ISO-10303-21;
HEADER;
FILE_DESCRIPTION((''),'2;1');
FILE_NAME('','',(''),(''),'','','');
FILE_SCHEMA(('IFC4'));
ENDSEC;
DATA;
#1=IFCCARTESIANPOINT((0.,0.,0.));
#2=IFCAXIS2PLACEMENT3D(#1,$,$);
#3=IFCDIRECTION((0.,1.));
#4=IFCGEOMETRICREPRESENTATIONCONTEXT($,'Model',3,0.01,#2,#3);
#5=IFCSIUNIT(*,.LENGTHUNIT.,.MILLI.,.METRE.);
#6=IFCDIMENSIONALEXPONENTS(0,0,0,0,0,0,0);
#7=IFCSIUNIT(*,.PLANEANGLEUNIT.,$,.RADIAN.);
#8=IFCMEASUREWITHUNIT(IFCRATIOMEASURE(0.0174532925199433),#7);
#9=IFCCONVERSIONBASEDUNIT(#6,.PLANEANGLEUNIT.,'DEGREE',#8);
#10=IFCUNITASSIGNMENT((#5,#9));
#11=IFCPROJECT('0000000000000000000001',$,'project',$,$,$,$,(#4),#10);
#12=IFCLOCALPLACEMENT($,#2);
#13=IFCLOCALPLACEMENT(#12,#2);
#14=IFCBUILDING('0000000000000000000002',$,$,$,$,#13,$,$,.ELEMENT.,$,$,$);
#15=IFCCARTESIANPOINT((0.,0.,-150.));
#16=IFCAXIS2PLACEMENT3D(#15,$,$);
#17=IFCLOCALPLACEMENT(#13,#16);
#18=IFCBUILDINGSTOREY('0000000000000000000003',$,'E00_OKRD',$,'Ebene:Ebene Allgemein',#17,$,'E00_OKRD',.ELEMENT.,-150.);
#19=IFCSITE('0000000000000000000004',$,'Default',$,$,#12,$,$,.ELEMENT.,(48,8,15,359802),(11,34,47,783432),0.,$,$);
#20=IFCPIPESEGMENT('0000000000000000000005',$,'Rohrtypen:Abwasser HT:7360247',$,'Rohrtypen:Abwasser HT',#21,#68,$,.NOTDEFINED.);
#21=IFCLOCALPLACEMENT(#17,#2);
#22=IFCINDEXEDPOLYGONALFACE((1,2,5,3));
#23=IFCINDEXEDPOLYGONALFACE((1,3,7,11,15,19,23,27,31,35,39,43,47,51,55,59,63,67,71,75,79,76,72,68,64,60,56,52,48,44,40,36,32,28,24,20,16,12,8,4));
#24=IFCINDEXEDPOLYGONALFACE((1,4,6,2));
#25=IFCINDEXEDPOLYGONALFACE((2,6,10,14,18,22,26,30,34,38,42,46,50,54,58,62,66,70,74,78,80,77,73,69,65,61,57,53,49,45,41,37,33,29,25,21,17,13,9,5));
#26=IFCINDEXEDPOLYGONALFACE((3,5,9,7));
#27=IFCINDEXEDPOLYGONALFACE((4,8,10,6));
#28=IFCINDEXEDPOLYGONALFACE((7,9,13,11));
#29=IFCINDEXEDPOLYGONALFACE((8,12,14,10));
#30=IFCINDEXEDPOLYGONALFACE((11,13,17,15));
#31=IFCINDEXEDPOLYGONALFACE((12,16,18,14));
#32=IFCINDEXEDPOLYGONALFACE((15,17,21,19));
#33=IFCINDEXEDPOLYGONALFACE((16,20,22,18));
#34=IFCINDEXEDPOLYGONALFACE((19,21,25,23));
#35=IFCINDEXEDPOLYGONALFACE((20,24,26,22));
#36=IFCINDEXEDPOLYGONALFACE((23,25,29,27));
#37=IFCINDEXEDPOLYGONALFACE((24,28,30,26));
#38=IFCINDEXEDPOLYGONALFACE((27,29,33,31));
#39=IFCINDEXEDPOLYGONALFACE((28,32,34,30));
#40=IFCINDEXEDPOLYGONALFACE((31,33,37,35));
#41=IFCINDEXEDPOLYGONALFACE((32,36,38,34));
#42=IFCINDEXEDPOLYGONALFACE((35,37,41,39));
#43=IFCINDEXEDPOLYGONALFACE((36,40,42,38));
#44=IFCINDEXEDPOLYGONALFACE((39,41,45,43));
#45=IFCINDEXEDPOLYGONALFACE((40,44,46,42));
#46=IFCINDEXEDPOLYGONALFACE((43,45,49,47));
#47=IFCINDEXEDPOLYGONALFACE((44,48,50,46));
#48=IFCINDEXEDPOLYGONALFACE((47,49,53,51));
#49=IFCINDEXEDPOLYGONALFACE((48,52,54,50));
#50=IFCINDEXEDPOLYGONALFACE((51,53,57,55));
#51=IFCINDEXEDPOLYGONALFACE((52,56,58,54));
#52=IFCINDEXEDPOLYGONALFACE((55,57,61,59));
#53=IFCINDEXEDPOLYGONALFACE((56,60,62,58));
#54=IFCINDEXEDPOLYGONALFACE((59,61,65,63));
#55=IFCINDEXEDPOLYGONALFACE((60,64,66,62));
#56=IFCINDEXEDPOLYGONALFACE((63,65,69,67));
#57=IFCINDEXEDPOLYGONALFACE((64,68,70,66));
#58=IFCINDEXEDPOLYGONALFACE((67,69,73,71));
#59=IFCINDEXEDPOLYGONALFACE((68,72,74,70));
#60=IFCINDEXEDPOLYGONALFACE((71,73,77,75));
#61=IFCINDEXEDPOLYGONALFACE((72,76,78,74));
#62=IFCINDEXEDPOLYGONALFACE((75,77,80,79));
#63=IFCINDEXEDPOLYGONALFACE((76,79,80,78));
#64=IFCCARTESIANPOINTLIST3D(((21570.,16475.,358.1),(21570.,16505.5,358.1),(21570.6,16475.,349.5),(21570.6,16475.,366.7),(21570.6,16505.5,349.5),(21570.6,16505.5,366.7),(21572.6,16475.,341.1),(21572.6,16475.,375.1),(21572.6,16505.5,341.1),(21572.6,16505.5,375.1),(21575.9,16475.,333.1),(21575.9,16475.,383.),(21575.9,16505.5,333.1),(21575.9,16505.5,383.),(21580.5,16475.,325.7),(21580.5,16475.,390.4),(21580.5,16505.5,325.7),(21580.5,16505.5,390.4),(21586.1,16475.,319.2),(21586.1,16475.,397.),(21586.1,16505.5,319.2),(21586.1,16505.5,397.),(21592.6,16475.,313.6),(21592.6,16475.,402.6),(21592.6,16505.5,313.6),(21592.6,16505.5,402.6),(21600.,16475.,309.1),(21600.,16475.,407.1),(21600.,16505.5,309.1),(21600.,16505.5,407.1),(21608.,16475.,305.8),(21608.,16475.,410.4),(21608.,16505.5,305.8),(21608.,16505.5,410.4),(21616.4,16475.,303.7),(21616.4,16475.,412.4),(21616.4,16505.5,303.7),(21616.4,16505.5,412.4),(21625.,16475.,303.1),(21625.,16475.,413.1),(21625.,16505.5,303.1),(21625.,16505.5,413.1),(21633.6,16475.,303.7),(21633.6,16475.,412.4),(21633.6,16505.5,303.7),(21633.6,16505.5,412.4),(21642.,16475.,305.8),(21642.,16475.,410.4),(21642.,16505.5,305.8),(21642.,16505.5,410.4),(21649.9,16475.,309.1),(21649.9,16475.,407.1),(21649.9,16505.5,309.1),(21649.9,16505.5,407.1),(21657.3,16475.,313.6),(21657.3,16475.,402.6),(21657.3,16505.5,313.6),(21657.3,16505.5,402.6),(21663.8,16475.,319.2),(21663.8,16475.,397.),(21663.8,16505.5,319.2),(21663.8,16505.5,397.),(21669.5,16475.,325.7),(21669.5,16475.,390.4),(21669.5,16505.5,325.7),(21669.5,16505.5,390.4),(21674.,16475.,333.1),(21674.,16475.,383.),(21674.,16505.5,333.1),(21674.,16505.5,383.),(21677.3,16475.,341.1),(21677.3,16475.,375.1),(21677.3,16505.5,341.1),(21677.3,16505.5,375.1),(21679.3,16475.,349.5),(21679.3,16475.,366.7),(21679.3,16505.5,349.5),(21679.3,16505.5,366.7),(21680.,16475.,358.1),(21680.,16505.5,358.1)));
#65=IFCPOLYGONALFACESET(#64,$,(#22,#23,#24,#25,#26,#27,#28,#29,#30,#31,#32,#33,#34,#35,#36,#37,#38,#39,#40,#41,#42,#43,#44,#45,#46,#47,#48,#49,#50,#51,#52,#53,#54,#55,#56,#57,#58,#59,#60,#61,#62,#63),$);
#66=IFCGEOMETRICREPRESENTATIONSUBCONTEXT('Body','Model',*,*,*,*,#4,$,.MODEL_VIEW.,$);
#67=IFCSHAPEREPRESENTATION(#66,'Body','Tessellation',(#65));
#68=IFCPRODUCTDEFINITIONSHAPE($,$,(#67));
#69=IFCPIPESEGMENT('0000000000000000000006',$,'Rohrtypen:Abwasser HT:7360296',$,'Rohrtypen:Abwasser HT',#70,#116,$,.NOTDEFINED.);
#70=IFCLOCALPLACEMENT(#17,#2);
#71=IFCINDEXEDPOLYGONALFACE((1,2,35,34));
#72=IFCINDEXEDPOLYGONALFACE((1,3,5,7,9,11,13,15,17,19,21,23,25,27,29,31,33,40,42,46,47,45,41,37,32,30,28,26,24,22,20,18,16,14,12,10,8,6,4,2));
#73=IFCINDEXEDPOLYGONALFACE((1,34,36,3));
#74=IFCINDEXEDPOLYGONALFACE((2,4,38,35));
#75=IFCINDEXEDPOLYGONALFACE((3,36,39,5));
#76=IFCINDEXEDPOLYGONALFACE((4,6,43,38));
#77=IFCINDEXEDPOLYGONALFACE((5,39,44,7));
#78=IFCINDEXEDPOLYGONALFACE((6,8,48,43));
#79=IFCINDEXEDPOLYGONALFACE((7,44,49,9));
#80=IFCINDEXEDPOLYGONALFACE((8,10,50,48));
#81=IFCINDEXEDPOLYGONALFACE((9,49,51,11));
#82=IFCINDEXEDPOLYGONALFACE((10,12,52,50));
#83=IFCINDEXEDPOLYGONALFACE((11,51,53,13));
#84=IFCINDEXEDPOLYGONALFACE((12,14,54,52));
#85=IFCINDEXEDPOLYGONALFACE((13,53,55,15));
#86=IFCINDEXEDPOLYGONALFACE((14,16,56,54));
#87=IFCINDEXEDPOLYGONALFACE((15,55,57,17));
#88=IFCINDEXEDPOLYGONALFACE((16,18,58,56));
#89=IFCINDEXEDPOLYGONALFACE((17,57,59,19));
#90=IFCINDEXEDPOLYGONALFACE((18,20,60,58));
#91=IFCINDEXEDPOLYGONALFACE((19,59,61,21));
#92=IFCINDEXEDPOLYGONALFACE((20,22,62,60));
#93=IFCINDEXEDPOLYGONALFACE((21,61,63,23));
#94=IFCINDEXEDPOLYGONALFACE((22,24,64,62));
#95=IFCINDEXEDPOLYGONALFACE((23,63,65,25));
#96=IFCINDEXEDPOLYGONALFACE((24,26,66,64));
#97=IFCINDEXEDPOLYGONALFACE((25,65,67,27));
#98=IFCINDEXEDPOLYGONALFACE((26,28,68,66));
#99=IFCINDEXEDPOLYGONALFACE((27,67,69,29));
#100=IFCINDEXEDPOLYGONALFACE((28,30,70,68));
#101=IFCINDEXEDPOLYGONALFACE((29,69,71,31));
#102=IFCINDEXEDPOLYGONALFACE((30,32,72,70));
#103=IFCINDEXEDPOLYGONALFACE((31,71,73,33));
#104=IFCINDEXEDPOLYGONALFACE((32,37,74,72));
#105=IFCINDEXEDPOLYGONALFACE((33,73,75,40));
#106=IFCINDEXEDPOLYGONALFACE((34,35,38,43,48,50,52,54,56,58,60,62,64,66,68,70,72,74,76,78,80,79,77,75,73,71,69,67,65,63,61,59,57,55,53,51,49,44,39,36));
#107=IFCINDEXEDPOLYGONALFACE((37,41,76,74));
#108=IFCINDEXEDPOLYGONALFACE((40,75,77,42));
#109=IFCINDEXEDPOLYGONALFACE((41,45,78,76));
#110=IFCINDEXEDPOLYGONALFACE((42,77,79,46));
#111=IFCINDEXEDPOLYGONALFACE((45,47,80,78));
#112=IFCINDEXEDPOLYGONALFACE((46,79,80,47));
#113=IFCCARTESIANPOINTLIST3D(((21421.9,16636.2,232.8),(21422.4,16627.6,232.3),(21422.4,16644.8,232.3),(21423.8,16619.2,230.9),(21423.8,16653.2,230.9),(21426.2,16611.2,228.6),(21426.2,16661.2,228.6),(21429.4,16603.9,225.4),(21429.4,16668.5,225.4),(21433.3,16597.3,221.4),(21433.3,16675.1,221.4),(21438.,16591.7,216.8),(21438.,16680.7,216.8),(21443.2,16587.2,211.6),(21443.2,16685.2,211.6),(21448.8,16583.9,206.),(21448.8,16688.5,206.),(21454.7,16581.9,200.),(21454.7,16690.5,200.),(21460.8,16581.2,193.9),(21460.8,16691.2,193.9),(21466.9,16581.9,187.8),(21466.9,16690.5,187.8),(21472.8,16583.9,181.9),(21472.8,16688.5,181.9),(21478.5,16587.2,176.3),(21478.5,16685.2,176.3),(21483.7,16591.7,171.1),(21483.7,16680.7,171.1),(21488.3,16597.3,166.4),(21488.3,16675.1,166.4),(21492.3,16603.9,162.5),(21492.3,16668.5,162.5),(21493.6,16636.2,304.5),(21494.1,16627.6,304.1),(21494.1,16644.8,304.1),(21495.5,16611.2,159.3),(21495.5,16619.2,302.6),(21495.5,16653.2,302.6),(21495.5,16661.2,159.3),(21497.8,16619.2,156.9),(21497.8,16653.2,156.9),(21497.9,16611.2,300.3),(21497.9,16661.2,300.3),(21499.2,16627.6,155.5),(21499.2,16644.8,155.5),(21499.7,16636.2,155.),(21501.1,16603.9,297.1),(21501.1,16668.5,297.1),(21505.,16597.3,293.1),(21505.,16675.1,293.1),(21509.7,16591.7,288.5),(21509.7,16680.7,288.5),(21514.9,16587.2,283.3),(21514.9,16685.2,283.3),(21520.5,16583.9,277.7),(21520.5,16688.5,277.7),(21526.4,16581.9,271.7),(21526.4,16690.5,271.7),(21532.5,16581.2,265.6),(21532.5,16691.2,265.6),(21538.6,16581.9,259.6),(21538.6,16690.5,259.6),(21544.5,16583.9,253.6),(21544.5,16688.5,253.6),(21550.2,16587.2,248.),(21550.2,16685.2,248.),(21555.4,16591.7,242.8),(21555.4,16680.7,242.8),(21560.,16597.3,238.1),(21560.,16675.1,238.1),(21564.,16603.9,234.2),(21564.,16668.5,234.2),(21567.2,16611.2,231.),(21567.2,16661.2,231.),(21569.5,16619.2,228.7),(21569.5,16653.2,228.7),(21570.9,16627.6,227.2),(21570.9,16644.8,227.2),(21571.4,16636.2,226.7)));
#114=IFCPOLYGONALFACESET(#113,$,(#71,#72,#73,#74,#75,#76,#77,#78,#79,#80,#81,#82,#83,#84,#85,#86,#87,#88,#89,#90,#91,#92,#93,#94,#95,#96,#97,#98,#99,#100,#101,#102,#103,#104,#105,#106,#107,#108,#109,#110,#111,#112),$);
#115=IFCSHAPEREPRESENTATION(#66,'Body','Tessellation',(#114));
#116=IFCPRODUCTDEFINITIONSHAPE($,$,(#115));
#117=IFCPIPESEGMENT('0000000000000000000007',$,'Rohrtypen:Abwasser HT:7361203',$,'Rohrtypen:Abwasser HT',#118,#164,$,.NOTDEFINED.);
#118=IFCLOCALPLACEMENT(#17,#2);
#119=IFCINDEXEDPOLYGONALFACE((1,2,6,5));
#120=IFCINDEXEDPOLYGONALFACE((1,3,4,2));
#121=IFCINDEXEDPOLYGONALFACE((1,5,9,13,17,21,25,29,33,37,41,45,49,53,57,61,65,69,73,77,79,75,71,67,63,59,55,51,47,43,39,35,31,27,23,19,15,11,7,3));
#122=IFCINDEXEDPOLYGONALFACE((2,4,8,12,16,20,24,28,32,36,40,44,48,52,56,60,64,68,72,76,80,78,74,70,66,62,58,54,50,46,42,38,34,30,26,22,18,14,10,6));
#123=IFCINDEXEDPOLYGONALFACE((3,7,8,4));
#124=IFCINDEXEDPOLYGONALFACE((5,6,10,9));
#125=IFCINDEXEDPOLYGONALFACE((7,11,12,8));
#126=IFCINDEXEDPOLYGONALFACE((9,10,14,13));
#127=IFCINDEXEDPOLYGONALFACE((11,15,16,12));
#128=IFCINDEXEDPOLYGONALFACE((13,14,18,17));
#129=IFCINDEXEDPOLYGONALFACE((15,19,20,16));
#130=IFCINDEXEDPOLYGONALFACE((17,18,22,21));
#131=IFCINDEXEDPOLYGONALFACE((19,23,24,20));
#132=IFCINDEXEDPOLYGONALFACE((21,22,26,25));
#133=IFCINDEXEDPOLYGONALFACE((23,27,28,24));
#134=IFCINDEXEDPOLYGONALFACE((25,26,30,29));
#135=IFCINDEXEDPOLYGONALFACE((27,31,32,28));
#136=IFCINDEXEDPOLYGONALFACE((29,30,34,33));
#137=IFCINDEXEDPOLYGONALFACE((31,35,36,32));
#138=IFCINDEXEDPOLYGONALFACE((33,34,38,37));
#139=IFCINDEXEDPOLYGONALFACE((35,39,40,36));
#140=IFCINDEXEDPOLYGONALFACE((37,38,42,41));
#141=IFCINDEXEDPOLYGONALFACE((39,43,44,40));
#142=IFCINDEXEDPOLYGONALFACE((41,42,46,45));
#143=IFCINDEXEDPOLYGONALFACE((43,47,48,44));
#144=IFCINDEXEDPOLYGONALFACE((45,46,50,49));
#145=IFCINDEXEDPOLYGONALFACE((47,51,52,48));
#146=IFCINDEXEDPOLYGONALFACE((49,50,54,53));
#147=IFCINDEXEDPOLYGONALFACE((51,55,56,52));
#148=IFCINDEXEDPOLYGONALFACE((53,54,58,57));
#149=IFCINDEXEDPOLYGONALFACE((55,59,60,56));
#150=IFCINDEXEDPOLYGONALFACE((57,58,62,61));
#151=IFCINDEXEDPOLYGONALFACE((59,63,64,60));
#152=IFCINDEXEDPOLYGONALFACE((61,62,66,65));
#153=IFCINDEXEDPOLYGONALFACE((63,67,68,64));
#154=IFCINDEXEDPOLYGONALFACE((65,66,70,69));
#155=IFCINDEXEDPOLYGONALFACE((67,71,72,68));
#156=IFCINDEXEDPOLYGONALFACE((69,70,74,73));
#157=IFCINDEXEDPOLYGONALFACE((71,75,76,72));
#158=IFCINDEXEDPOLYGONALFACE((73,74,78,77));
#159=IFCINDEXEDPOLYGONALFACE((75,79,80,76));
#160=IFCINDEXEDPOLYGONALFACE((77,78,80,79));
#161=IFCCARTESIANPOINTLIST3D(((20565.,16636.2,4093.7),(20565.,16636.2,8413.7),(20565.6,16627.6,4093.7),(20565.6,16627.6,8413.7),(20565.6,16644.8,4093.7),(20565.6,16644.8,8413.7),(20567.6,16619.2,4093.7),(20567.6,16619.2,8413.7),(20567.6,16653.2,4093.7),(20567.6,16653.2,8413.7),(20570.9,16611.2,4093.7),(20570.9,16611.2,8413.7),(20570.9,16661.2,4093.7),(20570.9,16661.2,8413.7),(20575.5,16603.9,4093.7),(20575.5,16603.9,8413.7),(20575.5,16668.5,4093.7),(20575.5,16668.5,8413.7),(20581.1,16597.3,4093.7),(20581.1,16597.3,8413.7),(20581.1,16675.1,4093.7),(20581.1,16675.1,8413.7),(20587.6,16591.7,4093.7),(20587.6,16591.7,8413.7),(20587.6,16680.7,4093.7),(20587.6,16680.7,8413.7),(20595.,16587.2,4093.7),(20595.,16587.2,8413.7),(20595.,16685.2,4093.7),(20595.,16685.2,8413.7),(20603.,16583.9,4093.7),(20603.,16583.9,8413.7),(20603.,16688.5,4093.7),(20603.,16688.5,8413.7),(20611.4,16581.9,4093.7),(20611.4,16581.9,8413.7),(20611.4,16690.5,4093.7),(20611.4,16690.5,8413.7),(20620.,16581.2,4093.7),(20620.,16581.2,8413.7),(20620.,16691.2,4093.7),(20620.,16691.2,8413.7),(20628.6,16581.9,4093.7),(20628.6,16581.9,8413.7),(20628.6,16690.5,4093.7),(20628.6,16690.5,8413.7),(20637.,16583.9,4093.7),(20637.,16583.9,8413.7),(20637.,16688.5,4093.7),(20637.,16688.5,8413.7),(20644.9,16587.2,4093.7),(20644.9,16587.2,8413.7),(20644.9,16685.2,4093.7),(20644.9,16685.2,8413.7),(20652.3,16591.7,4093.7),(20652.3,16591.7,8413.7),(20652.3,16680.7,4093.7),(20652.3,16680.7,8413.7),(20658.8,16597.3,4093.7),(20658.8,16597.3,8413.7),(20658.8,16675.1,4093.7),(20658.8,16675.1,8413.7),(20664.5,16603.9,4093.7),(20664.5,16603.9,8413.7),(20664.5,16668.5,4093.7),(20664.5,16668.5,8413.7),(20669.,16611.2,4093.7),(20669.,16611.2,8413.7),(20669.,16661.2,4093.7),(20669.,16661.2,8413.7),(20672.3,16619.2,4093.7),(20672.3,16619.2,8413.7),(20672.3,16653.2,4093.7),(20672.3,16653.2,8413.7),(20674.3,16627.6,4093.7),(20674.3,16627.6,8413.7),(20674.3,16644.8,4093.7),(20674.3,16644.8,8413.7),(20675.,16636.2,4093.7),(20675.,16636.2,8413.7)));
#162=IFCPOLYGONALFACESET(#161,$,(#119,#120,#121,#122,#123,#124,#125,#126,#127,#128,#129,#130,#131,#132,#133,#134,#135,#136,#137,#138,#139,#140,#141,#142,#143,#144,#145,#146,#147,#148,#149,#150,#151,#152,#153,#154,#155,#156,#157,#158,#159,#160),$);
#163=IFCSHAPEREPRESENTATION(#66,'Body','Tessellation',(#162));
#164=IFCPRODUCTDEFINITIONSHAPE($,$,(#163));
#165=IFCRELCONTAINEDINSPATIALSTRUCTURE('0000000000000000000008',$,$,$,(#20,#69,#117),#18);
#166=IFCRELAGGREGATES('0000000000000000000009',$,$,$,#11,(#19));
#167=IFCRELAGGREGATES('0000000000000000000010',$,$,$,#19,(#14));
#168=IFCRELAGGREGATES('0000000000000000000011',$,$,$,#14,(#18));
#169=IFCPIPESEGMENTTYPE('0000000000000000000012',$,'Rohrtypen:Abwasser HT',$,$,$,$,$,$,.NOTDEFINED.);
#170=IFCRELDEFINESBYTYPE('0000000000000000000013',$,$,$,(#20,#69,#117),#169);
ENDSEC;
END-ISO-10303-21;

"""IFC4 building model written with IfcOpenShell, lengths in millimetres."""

from ifc_helpers import new_model, entity, si_unit, converted_unit, direction, frame, origin, place, context, subcontext, project, spatial, indexed_curve, outline, extrude, type_object, element, save


model = new_model("IFC4")

# Units and contexts
model_context = context("Model", 3, precision=0.01, world=origin(), true_north=direction((0.0, 1.0)))
body_context = subcontext(model_context, "Body", "Model", "MODEL_VIEW")
ifc_project = project(units=[si_unit("LENGTHUNIT", "METRE", prefix="MILLI"), converted_unit("PLANEANGLEUNIT", "DEGREE", entity("IfcRatioMeasure", 0.0174532925199433), si_unit("PLANEANGLEUNIT", "RADIAN"), dimensions=[0, 0, 0, 0, 0, 0, 0])], contexts=[model_context])

# Site, building, storey
site_placement = place(None, origin())
site = spatial("IfcSite", under=ifc_project, at=site_placement, Name="Default", CompositionType="ELEMENT", RefLatitude=(48, 8, 15, 359802), RefLongitude=(11, 34, 47, 783432), RefElevation=0.0)
building_placement = place(site_placement, origin())
building = spatial("IfcBuilding", under=site, at=building_placement, CompositionType="ELEMENT")
storey_placement = place(building_placement, frame((0.0, 0.0, -150.0)))
storey = spatial("IfcBuildingStorey", under=building, at=storey_placement, Name="E00_OKRD", ObjectType="Ebene:Ebene Allgemein", LongName="E00_OKRD", CompositionType="ELEMENT", Elevation=-150.0)

# Pipe segments
pipe_segment_type_1 = type_object("IfcPipeSegmentType", Name="Rohrtypen:Abwasser HT", PredefinedType="NOTDEFINED")
pipe_segment_1_placement = place(storey_placement, origin())
element("IfcPipeSegment", 1, at=pipe_segment_1_placement, inside=storey, type_object=pipe_segment_type_1, Name="Rohrtypen:Abwasser HT:7360247", ObjectType="Rohrtypen:Abwasser HT", PredefinedType="NOTDEFINED", context=body_context, shape_type="SweptSolid", body=[
    extrude(outline(indexed_curve([(55.0, 0.0), (54.3, 8.6), (52.3, 17.0), (49.0, 25.0), (44.5, 32.3), (38.9, 38.9), (32.3, 44.5), (25.0, 49.0), (17.0, 52.3), (8.6, 54.3), (0.0, 55.0), (-8.6, 54.3), (-17.0, 52.3), (-25.0, 49.0), (-32.3, 44.5), (-38.9, 38.9), (-44.5, 32.3), (-49.0, 25.0), (-52.3, 17.0), (-54.3, 8.6), (-55.0, 0.0), (-54.3, -8.6), (-52.3, -17.0), (-49.0, -25.0), (-44.5, -32.3), (-38.9, -38.9), (-32.3, -44.5), (-25.0, -49.0), (-17.0, -52.3), (-8.6, -54.3), (0.0, -55.0), (8.6, -54.3), (17.0, -52.3), (25.0, -49.0), (32.3, -44.5), (38.9, -38.9), (44.5, -32.3), (49.0, -25.0), (52.3, -17.0), (54.3, -8.6), (55.0, 0.0)], self_intersect=False)), frame((21625.0, 16475.0, 358.1), z_axis=(0.0, 1.0, 0.0), x_axis=(1.0, 0.0, 0.0)), (0.0, 0.0, 1.0), 30.5),
])
pipe_segment_2_placement = place(storey_placement, origin())
element("IfcPipeSegment", 2, at=pipe_segment_2_placement, inside=storey, type_object=pipe_segment_type_1, Name="Rohrtypen:Abwasser HT:7360296", ObjectType="Rohrtypen:Abwasser HT", PredefinedType="NOTDEFINED", context=body_context, shape_type="SweptSolid", body=[
    extrude(outline(indexed_curve([(55.0, 0.0), (54.3, 8.6), (52.3, 17.0), (49.0, 25.0), (44.5, 32.3), (38.9, 38.9), (32.3, 44.5), (25.0, 49.0), (17.0, 52.3), (8.6, 54.3), (0.0, 55.0), (-8.6, 54.3), (-17.0, 52.3), (-25.0, 49.0), (-32.3, 44.5), (-38.9, 38.9), (-44.5, 32.3), (-49.0, 25.0), (-52.3, 17.0), (-54.3, 8.6), (-55.0, 0.0), (-54.3, -8.6), (-52.3, -17.0), (-49.0, -25.0), (-44.5, -32.3), (-38.9, -38.9), (-32.3, -44.5), (-25.0, -49.0), (-17.0, -52.3), (-8.6, -54.3), (0.0, -55.0), (8.6, -54.3), (17.0, -52.3), (25.0, -49.0), (32.3, -44.5), (38.9, -38.9), (44.5, -32.3), (49.0, -25.0), (52.3, -17.0), (54.3, -8.6), (55.0, 0.0)], self_intersect=False)), frame((21460.8, 16636.2, 193.9), z_axis=(0.707107, 0.0, 0.707107), x_axis=(0.0, 1.0, 0.0)), (0.0, 0.0, 1.0), 101.4),
])
pipe_segment_3_placement = place(storey_placement, origin())
element("IfcPipeSegment", 3, at=pipe_segment_3_placement, inside=storey, type_object=pipe_segment_type_1, Name="Rohrtypen:Abwasser HT:7361203", ObjectType="Rohrtypen:Abwasser HT", PredefinedType="NOTDEFINED", context=body_context, shape_type="SweptSolid", body=[
    extrude(outline(indexed_curve([(55.0, 0.0), (54.3, 8.6), (52.3, 17.0), (49.0, 25.0), (44.5, 32.3), (38.9, 38.9), (32.3, 44.5), (25.0, 49.0), (17.0, 52.3), (8.6, 54.3), (0.0, 55.0), (-8.6, 54.3), (-17.0, 52.3), (-25.0, 49.0), (-32.3, 44.5), (-38.9, 38.9), (-44.5, 32.3), (-49.0, 25.0), (-52.3, 17.0), (-54.3, 8.6), (-55.0, 0.0), (-54.3, -8.6), (-52.3, -17.0), (-49.0, -25.0), (-44.5, -32.3), (-38.9, -38.9), (-32.3, -44.5), (-25.0, -49.0), (-17.0, -52.3), (-8.6, -54.3), (0.0, -55.0), (8.6, -54.3), (17.0, -52.3), (25.0, -49.0), (32.3, -44.5), (38.9, -38.9), (44.5, -32.3), (49.0, -25.0), (52.3, -17.0), (54.3, -8.6), (55.0, 0.0)], self_intersect=False)), frame((20620.0, 16636.2, 4093.7), z_axis=(0.0, 0.0, 1.0), x_axis=(-1.0, 0.0, 0.0)), (0.0, 0.0, 1.0), 4320.0),
])

save(model, "model.ifc")
